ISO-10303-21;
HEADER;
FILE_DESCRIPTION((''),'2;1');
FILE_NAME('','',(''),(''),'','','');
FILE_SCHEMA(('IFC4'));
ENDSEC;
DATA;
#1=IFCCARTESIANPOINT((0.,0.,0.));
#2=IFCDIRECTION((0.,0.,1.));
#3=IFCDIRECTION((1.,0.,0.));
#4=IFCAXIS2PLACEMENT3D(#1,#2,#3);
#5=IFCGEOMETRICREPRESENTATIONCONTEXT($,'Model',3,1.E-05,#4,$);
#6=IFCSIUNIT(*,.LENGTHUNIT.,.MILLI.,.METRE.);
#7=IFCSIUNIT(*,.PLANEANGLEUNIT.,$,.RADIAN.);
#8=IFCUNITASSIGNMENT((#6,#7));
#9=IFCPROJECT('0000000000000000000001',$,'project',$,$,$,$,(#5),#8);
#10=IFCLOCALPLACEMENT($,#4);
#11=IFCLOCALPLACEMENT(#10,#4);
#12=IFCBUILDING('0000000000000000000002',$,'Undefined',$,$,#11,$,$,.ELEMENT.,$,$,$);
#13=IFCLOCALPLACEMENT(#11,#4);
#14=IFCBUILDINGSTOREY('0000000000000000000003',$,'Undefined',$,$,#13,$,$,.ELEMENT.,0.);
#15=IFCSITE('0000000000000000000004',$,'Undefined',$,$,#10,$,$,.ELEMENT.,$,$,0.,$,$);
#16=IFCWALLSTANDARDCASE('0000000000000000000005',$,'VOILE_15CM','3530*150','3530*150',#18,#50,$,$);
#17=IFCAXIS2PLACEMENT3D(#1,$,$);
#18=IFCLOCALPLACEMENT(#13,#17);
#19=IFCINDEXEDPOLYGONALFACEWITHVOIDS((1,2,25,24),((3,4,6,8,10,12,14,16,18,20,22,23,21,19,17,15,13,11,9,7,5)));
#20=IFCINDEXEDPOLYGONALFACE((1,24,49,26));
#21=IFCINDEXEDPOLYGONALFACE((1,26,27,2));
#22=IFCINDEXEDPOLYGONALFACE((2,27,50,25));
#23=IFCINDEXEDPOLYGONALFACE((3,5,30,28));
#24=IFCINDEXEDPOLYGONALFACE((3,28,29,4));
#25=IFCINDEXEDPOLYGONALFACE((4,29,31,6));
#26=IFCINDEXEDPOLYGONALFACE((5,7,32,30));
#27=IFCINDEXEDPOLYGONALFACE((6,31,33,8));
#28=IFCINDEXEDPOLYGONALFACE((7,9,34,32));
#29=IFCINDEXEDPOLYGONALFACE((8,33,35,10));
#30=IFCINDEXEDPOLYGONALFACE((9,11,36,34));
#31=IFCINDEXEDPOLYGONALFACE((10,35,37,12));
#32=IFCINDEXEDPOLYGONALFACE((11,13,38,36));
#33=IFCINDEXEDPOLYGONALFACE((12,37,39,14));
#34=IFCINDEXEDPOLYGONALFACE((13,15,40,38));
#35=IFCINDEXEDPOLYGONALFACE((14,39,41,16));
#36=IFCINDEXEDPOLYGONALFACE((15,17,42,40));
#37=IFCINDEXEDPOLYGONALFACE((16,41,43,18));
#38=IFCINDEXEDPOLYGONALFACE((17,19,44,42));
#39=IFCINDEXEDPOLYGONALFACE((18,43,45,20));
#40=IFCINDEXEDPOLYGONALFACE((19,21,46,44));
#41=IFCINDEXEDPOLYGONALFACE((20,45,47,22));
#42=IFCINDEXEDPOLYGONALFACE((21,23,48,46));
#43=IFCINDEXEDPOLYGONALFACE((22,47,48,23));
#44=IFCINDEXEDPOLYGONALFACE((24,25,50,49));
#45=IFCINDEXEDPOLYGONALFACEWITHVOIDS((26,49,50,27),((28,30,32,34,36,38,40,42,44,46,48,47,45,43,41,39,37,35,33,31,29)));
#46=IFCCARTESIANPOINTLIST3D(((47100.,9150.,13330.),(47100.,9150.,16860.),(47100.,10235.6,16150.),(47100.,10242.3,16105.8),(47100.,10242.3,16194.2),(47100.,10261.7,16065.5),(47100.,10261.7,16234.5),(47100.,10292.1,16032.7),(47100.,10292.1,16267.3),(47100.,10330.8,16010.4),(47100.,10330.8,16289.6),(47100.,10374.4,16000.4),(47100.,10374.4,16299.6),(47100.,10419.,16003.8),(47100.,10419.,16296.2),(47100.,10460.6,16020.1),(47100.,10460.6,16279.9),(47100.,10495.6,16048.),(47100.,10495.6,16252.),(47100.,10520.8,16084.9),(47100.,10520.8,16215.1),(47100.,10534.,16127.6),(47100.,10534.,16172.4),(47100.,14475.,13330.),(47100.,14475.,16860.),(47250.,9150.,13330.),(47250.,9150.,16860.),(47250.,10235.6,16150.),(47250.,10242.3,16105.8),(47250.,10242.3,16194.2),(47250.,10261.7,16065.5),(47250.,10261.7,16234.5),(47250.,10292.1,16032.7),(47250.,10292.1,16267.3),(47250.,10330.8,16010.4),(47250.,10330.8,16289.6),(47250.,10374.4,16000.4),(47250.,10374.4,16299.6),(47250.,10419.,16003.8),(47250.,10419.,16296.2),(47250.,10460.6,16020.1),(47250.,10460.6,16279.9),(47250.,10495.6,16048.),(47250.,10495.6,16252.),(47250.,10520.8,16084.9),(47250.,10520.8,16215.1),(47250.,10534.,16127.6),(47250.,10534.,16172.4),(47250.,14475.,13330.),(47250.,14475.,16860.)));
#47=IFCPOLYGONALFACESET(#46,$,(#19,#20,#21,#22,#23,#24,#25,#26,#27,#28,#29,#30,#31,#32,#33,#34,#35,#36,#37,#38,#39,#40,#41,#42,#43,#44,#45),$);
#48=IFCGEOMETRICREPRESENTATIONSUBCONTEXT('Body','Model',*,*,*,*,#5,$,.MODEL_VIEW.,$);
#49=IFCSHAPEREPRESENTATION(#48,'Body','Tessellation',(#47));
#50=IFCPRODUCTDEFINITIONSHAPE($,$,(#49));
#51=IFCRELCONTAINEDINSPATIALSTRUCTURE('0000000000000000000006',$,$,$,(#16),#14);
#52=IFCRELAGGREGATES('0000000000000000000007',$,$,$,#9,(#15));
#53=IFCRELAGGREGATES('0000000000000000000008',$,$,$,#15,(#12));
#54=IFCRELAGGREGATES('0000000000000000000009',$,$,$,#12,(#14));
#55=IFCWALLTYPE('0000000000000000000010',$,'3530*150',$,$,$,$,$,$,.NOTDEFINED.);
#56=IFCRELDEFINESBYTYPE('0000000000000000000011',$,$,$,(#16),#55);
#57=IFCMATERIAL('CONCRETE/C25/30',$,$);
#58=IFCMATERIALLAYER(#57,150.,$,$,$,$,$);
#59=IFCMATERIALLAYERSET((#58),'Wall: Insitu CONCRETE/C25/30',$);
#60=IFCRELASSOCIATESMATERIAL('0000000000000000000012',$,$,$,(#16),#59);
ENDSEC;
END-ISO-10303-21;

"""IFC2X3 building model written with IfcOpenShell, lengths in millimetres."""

from ifc_helpers import new_model, si_unit, frame, frame_2d, origin_with_axes, origin_2d_with_axis, place, context, subcontext, project, spatial, rectangle, circle, extrude, boolean, material, layer, layer_set, layer_usage, type_object, element, save


model = new_model("IFC2X3")

# Units and contexts
model_context = context("Model", 3, precision=1e-05, world=origin_with_axes())
body_context = subcontext(model_context, "Body", "Model", "MODEL_VIEW")
ifc_project = project(units=[si_unit("LENGTHUNIT", "METRE", prefix="MILLI"), si_unit("PLANEANGLEUNIT", "RADIAN")], contexts=[model_context])

# Site, building, storey
site_placement = place(None, origin_with_axes())
site = spatial("IfcSite", under=ifc_project, at=site_placement, Name="Undefined", CompositionType="ELEMENT", RefElevation=0.0)
building_placement = place(site_placement, origin_with_axes())
building = spatial("IfcBuilding", under=site, at=building_placement, Name="Undefined", CompositionType="ELEMENT")
storey_placement = place(building_placement, origin_with_axes())
storey = spatial("IfcBuildingStorey", under=building, at=storey_placement, Name="Undefined", CompositionType="ELEMENT", Elevation=0.0)

# Shared definitions
ifc_material_1 = material(Name="CONCRETE/C25/30")

# Wall
ifc_layer_1 = layer(ifc_material_1, 150.0)
ifc_layer_set_1 = layer_set([ifc_layer_1], Name="Wall: Insitu CONCRETE/C25/30")
wall_type_1 = type_object("IfcWallType", Name="3530*150", PredefinedType="NOTDEFINED")
ifc_layer_usage_1 = layer_usage(ifc_layer_set_1, "AXIS2", "POSITIVE", -75.0)
wall_1_placement = place(storey_placement, frame((47175.0, 9150.0, 13330.0), z_axis=(0.0, 0.0, 1.0), x_axis=(0.0, 1.0, 0.0)))
element("IfcWallStandardCase", 1, at=wall_1_placement, inside=storey, type_object=wall_type_1, material=ifc_layer_usage_1, Name="VOILE_15CM", Description="3530*150", ObjectType="3530*150", context=body_context, shape_type="CSG", body=[
    boolean("DIFFERENCE", extrude(rectangle(XDim=5325.0, YDim=150.0, at=frame_2d((0.0, 2662.5), x_axis=(0.0, -1.0))), frame((0.0, 0.0, 0.0), z_axis=(0.0, 0.0, 1.0), x_axis=(0.0, -1.0, 0.0)), (0.0, 0.0, 1.0), 3530.0), extrude(circle(Radius=150.0, at=origin_2d_with_axis()), frame((1235.6, -85.0, 2820.0), z_axis=(0.0, 1.0, 0.0), x_axis=(-1.0, 0.0, 0.0)), (0.0, 0.0, 1.0), 170.0)),
])

save(model, "model.ifc")
